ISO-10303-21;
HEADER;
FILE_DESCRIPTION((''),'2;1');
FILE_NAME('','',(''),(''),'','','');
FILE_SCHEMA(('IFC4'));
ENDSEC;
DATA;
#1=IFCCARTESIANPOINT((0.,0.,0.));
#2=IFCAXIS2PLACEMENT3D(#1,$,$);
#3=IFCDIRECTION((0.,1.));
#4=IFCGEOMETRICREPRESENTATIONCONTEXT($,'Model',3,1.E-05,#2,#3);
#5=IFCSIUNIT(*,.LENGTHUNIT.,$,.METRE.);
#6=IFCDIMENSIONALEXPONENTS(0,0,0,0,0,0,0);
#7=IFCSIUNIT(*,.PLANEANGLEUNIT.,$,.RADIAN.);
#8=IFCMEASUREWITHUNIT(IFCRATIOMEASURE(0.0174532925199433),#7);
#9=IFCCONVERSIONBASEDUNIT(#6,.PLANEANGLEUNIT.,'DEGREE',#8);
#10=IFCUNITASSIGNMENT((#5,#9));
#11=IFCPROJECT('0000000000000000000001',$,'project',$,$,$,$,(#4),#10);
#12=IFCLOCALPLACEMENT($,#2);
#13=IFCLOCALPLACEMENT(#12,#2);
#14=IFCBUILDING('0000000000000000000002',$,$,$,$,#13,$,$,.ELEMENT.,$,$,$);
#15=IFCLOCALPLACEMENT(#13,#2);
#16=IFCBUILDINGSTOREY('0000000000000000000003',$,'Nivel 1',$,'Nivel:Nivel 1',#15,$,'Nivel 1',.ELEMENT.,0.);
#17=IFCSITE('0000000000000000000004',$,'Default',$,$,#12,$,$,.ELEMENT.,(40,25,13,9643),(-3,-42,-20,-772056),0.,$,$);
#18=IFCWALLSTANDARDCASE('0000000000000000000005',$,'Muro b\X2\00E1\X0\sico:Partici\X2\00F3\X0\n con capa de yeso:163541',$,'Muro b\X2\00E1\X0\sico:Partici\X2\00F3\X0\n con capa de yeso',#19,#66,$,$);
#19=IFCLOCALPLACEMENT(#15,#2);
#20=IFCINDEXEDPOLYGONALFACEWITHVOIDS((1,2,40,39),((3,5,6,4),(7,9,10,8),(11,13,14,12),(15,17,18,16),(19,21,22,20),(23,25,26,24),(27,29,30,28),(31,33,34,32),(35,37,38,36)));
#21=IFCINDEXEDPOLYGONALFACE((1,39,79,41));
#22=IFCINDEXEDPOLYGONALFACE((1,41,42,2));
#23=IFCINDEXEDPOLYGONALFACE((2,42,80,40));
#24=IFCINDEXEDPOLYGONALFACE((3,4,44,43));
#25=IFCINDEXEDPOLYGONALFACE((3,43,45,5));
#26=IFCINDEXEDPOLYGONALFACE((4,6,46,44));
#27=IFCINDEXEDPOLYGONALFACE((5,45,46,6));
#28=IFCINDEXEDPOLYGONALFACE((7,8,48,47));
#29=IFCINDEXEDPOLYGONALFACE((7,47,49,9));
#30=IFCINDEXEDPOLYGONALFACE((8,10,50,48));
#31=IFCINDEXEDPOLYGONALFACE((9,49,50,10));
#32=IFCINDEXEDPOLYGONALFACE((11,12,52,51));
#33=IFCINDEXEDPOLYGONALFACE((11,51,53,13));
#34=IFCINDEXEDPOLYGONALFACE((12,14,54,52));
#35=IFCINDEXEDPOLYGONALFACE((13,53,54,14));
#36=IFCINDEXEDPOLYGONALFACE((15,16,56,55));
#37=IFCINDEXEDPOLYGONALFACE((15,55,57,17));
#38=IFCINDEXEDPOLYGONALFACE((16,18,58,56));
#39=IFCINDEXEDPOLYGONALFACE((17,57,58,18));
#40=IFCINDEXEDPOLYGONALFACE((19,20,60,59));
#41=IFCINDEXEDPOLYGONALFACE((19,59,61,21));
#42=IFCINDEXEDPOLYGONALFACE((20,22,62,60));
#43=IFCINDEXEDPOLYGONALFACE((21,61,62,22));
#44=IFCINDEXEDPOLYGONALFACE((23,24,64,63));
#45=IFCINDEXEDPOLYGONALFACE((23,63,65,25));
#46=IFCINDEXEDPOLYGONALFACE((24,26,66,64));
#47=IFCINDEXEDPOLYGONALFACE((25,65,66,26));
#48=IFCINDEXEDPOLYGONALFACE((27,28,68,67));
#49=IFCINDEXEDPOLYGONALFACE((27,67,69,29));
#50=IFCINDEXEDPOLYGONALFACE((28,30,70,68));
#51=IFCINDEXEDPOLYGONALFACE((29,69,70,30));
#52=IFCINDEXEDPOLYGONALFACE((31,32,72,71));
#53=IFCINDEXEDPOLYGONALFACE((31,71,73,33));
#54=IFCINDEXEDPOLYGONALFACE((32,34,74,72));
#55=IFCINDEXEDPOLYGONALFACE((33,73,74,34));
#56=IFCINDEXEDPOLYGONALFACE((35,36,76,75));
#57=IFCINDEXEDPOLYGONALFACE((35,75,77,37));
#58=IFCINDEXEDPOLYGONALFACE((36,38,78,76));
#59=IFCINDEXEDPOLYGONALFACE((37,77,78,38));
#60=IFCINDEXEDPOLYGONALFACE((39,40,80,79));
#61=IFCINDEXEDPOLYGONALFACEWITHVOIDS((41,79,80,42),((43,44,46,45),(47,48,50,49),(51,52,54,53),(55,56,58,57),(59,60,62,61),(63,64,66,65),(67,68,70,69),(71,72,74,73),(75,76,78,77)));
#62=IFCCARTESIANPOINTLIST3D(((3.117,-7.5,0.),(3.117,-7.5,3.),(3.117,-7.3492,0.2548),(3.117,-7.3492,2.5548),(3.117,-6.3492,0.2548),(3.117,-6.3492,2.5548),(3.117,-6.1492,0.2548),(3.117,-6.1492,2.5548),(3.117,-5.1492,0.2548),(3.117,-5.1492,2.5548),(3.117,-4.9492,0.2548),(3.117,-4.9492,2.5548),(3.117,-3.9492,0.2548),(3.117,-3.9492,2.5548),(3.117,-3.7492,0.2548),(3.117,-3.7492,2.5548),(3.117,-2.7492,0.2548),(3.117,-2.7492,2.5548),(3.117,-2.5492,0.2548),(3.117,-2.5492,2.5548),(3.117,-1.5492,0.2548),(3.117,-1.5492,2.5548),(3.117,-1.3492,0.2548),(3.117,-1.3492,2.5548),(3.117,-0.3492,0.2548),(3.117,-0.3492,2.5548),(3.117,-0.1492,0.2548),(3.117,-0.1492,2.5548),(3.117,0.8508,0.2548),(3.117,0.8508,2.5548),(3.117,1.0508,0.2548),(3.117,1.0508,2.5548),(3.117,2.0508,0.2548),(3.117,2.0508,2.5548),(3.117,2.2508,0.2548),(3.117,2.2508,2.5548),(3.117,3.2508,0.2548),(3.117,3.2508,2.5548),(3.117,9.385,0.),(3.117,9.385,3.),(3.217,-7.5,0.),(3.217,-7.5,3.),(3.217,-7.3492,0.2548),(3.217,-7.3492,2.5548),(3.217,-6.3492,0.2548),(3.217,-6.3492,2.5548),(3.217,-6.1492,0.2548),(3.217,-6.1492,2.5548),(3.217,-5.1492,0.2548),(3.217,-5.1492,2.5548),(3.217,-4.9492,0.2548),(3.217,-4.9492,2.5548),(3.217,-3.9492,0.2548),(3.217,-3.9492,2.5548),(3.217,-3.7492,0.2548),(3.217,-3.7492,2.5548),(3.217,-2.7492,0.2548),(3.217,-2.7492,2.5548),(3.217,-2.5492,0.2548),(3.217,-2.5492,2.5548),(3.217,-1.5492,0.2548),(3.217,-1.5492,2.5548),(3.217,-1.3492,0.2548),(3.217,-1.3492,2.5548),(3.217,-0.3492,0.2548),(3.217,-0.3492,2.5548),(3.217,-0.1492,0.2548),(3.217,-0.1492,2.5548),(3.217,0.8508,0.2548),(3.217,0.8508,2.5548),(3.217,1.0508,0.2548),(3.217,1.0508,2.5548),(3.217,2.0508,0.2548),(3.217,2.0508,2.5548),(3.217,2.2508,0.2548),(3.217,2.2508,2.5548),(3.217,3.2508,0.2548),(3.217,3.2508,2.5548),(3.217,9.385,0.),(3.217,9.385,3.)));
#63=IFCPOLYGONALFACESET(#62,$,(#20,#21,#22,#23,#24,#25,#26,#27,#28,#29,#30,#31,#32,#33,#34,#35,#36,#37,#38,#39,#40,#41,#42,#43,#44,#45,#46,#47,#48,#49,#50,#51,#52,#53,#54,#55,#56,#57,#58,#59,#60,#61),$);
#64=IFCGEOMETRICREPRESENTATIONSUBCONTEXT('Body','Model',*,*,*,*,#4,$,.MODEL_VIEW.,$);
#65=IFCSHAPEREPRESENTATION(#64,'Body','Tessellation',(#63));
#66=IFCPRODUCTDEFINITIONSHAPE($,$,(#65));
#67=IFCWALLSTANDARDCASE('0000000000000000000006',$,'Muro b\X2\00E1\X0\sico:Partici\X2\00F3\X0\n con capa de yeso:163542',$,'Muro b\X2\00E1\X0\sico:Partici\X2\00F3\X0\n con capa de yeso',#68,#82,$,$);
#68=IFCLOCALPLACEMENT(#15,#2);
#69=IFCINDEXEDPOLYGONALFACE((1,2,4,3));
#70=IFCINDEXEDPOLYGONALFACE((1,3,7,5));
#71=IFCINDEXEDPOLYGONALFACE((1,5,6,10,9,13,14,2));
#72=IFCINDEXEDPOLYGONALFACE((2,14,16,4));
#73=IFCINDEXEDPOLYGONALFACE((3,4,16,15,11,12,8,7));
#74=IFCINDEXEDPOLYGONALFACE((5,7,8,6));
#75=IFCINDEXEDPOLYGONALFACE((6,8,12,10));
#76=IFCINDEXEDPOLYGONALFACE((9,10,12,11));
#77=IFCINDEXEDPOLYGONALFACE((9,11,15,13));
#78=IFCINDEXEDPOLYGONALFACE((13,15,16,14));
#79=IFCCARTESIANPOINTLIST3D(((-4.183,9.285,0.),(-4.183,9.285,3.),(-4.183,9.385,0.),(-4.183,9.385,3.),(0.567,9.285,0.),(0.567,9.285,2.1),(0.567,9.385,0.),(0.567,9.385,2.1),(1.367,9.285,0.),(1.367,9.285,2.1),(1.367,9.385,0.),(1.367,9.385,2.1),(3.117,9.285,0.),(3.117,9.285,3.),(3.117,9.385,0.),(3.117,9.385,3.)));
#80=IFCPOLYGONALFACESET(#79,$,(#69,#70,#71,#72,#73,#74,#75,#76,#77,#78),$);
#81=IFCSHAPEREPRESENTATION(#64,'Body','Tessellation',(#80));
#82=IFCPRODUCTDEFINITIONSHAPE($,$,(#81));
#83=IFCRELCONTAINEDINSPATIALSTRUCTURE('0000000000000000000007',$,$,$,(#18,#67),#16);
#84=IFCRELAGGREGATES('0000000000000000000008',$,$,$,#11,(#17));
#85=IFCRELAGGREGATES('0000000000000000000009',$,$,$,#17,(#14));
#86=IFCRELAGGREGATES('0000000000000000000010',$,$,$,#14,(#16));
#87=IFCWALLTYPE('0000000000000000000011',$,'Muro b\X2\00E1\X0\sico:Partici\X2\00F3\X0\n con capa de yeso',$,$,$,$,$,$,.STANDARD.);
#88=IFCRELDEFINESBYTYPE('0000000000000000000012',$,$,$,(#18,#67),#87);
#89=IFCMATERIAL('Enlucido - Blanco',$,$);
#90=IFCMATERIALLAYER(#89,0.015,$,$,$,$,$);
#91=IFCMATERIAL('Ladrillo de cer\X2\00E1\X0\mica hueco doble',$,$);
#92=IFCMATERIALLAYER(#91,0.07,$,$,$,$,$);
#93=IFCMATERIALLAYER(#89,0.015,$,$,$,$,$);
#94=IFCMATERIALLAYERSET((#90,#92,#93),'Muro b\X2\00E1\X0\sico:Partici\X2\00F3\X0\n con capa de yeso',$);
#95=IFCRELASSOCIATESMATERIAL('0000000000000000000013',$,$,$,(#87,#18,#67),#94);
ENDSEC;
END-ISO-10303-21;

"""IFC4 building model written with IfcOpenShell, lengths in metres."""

from ifc_helpers import new_model, entity, si_unit, converted_unit, direction, frame, frame_2d, origin, place, context, subcontext, project, spatial, rectangle, extrude, material, layer, layer_set, layer_usage, type_object, element, save


model = new_model("IFC4")

# Units and contexts
model_context = context("Model", 3, precision=1e-05, world=origin(), true_north=direction((0.0, 1.0)))
body_context = subcontext(model_context, "Body", "Model", "MODEL_VIEW")
ifc_project = project(units=[si_unit("LENGTHUNIT", "METRE"), converted_unit("PLANEANGLEUNIT", "DEGREE", entity("IfcRatioMeasure", 0.0174532925199433), si_unit("PLANEANGLEUNIT", "RADIAN"), dimensions=[0, 0, 0, 0, 0, 0, 0])], contexts=[model_context])

# Site, building, storey
site_placement = place(None, origin())
site = spatial("IfcSite", under=ifc_project, at=site_placement, Name="Default", CompositionType="ELEMENT", RefLatitude=(40, 25, 13, 9643), RefLongitude=(-3, -42, -20, -772056), RefElevation=0.0)
building_placement = place(site_placement, origin())
building = spatial("IfcBuilding", under=site, at=building_placement, CompositionType="ELEMENT")
storey_placement = place(building_placement, origin())
storey = spatial("IfcBuildingStorey", under=building, at=storey_placement, Name="Nivel 1", ObjectType="Nivel:Nivel 1", LongName="Nivel 1", CompositionType="ELEMENT", Elevation=0.0)

# Wall, openings
ifc_material_1 = material(Name="Enlucido - Blanco")
ifc_layer_1 = layer(ifc_material_1, 0.015)
ifc_material_2 = material(Name="Ladrillo de cerámica hueco doble")
ifc_layer_2 = layer(ifc_material_2, 0.07)
ifc_layer_3 = layer(ifc_material_1, 0.015)
ifc_layer_set_1 = layer_set([ifc_layer_1, ifc_layer_2, ifc_layer_3], Name="Muro básico:Partición con capa de yeso")
ifc_layer_usage_1 = layer_usage(ifc_layer_set_1, "AXIS2", "NEGATIVE", 0.05)
wall_type = type_object("IfcWallType", Name="Muro básico:Partición con capa de yeso", PredefinedType="STANDARD", material=ifc_layer_set_1)
wall_1_placement = place(storey_placement, frame((3.167, 9.385, 0.0), z_axis=(0.0, 0.0, 1.0), x_axis=(0.0, -1.0, 0.0)))
wall_1 = element("IfcWallStandardCase", 1, at=wall_1_placement, inside=storey, type_object=wall_type, material=ifc_layer_usage_1, Name="Muro básico:Partición con capa de yeso:163541", ObjectType="Muro básico:Partición con capa de yeso", context=body_context, shape_type="SweptSolid", body=[
    extrude(rectangle(XDim=16.885, YDim=0.1, at=frame_2d((8.4425, 0.0), x_axis=(-1.0, 0.0))), origin(), (0.0, 0.0, 1.0), 3.0),
])
opening_1_placement = place(wall_1_placement, frame((7.3342, -0.05, 0.2548)))
element("IfcOpeningElement", 2, at=opening_1_placement, cuts=wall_1, ObjectType="Opening", context=body_context, shape_type="SweptSolid", body=[
    extrude(rectangle(XDim=2.3, YDim=1.0, at=frame_2d((1.15, 0.5), x_axis=(1.0, 0.0))), frame((0.0, 0.0, 0.0), z_axis=(0.0, 1.0, 0.0), x_axis=(0.0, 0.0, 1.0)), (0.0, 0.0, 1.0), 0.1),
])
opening_2_placement = place(wall_1_placement, frame((6.1342, -0.05, 0.2548)))
element("IfcOpeningElement", 3, at=opening_2_placement, cuts=wall_1, ObjectType="Opening", context=body_context, shape_type="SweptSolid", body=[
    extrude(rectangle(XDim=2.3, YDim=1.0, at=frame_2d((1.15, 0.5), x_axis=(1.0, 0.0))), frame((0.0, 0.0, 0.0), z_axis=(0.0, 1.0, 0.0), x_axis=(0.0, 0.0, 1.0)), (0.0, 0.0, 1.0), 0.1),
])
opening_3_placement = place(wall_1_placement, frame((10.9342, -0.05, 0.2548)))
element("IfcOpeningElement", 4, at=opening_3_placement, cuts=wall_1, ObjectType="Opening", context=body_context, shape_type="SweptSolid", body=[
    extrude(rectangle(XDim=2.3, YDim=1.0, at=frame_2d((1.15, 0.5), x_axis=(1.0, 0.0))), frame((0.0, 0.0, 0.0), z_axis=(0.0, 1.0, 0.0), x_axis=(0.0, 0.0, 1.0)), (0.0, 0.0, 1.0), 0.1),
])
opening_4_placement = place(wall_1_placement, frame((9.7342, -0.05, 0.2548)))
element("IfcOpeningElement", 5, at=opening_4_placement, cuts=wall_1, ObjectType="Opening", context=body_context, shape_type="SweptSolid", body=[
    extrude(rectangle(XDim=2.3, YDim=1.0, at=frame_2d((1.15, 0.5), x_axis=(1.0, 0.0))), frame((0.0, 0.0, 0.0), z_axis=(0.0, 1.0, 0.0), x_axis=(0.0, 0.0, 1.0)), (0.0, 0.0, 1.0), 0.1),
])
opening_5_placement = place(wall_1_placement, frame((8.5342, -0.05, 0.2548)))
element("IfcOpeningElement", 6, at=opening_5_placement, cuts=wall_1, ObjectType="Opening", context=body_context, shape_type="SweptSolid", body=[
    extrude(rectangle(XDim=2.3, YDim=1.0, at=frame_2d((1.15, 0.5), x_axis=(1.0, 0.0))), frame((0.0, 0.0, 0.0), z_axis=(0.0, 1.0, 0.0), x_axis=(0.0, 0.0, 1.0)), (0.0, 0.0, 1.0), 0.1),
])
opening_6_placement = place(wall_1_placement, frame((13.3342, -0.05, 0.2548)))
element("IfcOpeningElement", 7, at=opening_6_placement, cuts=wall_1, ObjectType="Opening", context=body_context, shape_type="SweptSolid", body=[
    extrude(rectangle(XDim=2.3, YDim=1.0, at=frame_2d((1.15, 0.5), x_axis=(1.0, 0.0))), frame((0.0, 0.0, 0.0), z_axis=(0.0, 1.0, 0.0), x_axis=(0.0, 0.0, 1.0)), (0.0, 0.0, 1.0), 0.1),
])
opening_7_placement = place(wall_1_placement, frame((12.1342, -0.05, 0.2548)))
element("IfcOpeningElement", 8, at=opening_7_placement, cuts=wall_1, ObjectType="Opening", context=body_context, shape_type="SweptSolid", body=[
    extrude(rectangle(XDim=2.3, YDim=1.0, at=frame_2d((1.15, 0.5), x_axis=(1.0, 0.0))), frame((0.0, 0.0, 0.0), z_axis=(0.0, 1.0, 0.0), x_axis=(0.0, 0.0, 1.0)), (0.0, 0.0, 1.0), 0.1),
])
opening_8_placement = place(wall_1_placement, frame((15.7342, -0.05, 0.2548)))
element("IfcOpeningElement", 9, at=opening_8_placement, cuts=wall_1, ObjectType="Opening", context=body_context, shape_type="SweptSolid", body=[
    extrude(rectangle(XDim=2.3, YDim=1.0, at=frame_2d((1.15, 0.5), x_axis=(1.0, 0.0))), frame((0.0, 0.0, 0.0), z_axis=(0.0, 1.0, 0.0), x_axis=(0.0, 0.0, 1.0)), (0.0, 0.0, 1.0), 0.1),
])
opening_9_placement = place(wall_1_placement, frame((14.5342, -0.05, 0.2548)))
element("IfcOpeningElement", 10, at=opening_9_placement, cuts=wall_1, ObjectType="Opening", context=body_context, shape_type="SweptSolid", body=[
    extrude(rectangle(XDim=2.3, YDim=1.0, at=frame_2d((1.15, 0.5), x_axis=(1.0, 0.0))), frame((0.0, 0.0, 0.0), z_axis=(0.0, 1.0, 0.0), x_axis=(0.0, 0.0, 1.0)), (0.0, 0.0, 1.0), 0.1),
])

# Wall, opening
ifc_layer_usage_2 = layer_usage(ifc_layer_set_1, "AXIS2", "NEGATIVE", 0.05)
wall_2_placement = place(storey_placement, frame((-4.183, 9.335, 0.0)))
wall_2 = element("IfcWallStandardCase", 11, at=wall_2_placement, inside=storey, type_object=wall_type, material=ifc_layer_usage_2, Name="Muro básico:Partición con capa de yeso:163542", ObjectType="Muro básico:Partición con capa de yeso", context=body_context, shape_type="SweptSolid", body=[
    extrude(rectangle(XDim=7.3, YDim=0.1, at=frame_2d((3.65, 0.0), x_axis=(-1.0, 0.0))), origin(), (0.0, 0.0, 1.0), 3.0),
])
opening_10_placement = place(wall_2_placement, frame((5.55, 0.05, 0.0)))
element("IfcOpeningElement", 12, at=opening_10_placement, cuts=wall_2, ObjectType="Opening", context=body_context, shape_type="SweptSolid", body=[
    extrude(rectangle(XDim=2.1, YDim=0.8, at=frame_2d((1.05, 0.4), x_axis=(1.0, 0.0))), frame((0.0, 0.0, 0.0), z_axis=(0.0, -1.0, 0.0), x_axis=(0.0, 0.0, 1.0)), (0.0, 0.0, 1.0), 0.1),
])

save(model, "model.ifc")
